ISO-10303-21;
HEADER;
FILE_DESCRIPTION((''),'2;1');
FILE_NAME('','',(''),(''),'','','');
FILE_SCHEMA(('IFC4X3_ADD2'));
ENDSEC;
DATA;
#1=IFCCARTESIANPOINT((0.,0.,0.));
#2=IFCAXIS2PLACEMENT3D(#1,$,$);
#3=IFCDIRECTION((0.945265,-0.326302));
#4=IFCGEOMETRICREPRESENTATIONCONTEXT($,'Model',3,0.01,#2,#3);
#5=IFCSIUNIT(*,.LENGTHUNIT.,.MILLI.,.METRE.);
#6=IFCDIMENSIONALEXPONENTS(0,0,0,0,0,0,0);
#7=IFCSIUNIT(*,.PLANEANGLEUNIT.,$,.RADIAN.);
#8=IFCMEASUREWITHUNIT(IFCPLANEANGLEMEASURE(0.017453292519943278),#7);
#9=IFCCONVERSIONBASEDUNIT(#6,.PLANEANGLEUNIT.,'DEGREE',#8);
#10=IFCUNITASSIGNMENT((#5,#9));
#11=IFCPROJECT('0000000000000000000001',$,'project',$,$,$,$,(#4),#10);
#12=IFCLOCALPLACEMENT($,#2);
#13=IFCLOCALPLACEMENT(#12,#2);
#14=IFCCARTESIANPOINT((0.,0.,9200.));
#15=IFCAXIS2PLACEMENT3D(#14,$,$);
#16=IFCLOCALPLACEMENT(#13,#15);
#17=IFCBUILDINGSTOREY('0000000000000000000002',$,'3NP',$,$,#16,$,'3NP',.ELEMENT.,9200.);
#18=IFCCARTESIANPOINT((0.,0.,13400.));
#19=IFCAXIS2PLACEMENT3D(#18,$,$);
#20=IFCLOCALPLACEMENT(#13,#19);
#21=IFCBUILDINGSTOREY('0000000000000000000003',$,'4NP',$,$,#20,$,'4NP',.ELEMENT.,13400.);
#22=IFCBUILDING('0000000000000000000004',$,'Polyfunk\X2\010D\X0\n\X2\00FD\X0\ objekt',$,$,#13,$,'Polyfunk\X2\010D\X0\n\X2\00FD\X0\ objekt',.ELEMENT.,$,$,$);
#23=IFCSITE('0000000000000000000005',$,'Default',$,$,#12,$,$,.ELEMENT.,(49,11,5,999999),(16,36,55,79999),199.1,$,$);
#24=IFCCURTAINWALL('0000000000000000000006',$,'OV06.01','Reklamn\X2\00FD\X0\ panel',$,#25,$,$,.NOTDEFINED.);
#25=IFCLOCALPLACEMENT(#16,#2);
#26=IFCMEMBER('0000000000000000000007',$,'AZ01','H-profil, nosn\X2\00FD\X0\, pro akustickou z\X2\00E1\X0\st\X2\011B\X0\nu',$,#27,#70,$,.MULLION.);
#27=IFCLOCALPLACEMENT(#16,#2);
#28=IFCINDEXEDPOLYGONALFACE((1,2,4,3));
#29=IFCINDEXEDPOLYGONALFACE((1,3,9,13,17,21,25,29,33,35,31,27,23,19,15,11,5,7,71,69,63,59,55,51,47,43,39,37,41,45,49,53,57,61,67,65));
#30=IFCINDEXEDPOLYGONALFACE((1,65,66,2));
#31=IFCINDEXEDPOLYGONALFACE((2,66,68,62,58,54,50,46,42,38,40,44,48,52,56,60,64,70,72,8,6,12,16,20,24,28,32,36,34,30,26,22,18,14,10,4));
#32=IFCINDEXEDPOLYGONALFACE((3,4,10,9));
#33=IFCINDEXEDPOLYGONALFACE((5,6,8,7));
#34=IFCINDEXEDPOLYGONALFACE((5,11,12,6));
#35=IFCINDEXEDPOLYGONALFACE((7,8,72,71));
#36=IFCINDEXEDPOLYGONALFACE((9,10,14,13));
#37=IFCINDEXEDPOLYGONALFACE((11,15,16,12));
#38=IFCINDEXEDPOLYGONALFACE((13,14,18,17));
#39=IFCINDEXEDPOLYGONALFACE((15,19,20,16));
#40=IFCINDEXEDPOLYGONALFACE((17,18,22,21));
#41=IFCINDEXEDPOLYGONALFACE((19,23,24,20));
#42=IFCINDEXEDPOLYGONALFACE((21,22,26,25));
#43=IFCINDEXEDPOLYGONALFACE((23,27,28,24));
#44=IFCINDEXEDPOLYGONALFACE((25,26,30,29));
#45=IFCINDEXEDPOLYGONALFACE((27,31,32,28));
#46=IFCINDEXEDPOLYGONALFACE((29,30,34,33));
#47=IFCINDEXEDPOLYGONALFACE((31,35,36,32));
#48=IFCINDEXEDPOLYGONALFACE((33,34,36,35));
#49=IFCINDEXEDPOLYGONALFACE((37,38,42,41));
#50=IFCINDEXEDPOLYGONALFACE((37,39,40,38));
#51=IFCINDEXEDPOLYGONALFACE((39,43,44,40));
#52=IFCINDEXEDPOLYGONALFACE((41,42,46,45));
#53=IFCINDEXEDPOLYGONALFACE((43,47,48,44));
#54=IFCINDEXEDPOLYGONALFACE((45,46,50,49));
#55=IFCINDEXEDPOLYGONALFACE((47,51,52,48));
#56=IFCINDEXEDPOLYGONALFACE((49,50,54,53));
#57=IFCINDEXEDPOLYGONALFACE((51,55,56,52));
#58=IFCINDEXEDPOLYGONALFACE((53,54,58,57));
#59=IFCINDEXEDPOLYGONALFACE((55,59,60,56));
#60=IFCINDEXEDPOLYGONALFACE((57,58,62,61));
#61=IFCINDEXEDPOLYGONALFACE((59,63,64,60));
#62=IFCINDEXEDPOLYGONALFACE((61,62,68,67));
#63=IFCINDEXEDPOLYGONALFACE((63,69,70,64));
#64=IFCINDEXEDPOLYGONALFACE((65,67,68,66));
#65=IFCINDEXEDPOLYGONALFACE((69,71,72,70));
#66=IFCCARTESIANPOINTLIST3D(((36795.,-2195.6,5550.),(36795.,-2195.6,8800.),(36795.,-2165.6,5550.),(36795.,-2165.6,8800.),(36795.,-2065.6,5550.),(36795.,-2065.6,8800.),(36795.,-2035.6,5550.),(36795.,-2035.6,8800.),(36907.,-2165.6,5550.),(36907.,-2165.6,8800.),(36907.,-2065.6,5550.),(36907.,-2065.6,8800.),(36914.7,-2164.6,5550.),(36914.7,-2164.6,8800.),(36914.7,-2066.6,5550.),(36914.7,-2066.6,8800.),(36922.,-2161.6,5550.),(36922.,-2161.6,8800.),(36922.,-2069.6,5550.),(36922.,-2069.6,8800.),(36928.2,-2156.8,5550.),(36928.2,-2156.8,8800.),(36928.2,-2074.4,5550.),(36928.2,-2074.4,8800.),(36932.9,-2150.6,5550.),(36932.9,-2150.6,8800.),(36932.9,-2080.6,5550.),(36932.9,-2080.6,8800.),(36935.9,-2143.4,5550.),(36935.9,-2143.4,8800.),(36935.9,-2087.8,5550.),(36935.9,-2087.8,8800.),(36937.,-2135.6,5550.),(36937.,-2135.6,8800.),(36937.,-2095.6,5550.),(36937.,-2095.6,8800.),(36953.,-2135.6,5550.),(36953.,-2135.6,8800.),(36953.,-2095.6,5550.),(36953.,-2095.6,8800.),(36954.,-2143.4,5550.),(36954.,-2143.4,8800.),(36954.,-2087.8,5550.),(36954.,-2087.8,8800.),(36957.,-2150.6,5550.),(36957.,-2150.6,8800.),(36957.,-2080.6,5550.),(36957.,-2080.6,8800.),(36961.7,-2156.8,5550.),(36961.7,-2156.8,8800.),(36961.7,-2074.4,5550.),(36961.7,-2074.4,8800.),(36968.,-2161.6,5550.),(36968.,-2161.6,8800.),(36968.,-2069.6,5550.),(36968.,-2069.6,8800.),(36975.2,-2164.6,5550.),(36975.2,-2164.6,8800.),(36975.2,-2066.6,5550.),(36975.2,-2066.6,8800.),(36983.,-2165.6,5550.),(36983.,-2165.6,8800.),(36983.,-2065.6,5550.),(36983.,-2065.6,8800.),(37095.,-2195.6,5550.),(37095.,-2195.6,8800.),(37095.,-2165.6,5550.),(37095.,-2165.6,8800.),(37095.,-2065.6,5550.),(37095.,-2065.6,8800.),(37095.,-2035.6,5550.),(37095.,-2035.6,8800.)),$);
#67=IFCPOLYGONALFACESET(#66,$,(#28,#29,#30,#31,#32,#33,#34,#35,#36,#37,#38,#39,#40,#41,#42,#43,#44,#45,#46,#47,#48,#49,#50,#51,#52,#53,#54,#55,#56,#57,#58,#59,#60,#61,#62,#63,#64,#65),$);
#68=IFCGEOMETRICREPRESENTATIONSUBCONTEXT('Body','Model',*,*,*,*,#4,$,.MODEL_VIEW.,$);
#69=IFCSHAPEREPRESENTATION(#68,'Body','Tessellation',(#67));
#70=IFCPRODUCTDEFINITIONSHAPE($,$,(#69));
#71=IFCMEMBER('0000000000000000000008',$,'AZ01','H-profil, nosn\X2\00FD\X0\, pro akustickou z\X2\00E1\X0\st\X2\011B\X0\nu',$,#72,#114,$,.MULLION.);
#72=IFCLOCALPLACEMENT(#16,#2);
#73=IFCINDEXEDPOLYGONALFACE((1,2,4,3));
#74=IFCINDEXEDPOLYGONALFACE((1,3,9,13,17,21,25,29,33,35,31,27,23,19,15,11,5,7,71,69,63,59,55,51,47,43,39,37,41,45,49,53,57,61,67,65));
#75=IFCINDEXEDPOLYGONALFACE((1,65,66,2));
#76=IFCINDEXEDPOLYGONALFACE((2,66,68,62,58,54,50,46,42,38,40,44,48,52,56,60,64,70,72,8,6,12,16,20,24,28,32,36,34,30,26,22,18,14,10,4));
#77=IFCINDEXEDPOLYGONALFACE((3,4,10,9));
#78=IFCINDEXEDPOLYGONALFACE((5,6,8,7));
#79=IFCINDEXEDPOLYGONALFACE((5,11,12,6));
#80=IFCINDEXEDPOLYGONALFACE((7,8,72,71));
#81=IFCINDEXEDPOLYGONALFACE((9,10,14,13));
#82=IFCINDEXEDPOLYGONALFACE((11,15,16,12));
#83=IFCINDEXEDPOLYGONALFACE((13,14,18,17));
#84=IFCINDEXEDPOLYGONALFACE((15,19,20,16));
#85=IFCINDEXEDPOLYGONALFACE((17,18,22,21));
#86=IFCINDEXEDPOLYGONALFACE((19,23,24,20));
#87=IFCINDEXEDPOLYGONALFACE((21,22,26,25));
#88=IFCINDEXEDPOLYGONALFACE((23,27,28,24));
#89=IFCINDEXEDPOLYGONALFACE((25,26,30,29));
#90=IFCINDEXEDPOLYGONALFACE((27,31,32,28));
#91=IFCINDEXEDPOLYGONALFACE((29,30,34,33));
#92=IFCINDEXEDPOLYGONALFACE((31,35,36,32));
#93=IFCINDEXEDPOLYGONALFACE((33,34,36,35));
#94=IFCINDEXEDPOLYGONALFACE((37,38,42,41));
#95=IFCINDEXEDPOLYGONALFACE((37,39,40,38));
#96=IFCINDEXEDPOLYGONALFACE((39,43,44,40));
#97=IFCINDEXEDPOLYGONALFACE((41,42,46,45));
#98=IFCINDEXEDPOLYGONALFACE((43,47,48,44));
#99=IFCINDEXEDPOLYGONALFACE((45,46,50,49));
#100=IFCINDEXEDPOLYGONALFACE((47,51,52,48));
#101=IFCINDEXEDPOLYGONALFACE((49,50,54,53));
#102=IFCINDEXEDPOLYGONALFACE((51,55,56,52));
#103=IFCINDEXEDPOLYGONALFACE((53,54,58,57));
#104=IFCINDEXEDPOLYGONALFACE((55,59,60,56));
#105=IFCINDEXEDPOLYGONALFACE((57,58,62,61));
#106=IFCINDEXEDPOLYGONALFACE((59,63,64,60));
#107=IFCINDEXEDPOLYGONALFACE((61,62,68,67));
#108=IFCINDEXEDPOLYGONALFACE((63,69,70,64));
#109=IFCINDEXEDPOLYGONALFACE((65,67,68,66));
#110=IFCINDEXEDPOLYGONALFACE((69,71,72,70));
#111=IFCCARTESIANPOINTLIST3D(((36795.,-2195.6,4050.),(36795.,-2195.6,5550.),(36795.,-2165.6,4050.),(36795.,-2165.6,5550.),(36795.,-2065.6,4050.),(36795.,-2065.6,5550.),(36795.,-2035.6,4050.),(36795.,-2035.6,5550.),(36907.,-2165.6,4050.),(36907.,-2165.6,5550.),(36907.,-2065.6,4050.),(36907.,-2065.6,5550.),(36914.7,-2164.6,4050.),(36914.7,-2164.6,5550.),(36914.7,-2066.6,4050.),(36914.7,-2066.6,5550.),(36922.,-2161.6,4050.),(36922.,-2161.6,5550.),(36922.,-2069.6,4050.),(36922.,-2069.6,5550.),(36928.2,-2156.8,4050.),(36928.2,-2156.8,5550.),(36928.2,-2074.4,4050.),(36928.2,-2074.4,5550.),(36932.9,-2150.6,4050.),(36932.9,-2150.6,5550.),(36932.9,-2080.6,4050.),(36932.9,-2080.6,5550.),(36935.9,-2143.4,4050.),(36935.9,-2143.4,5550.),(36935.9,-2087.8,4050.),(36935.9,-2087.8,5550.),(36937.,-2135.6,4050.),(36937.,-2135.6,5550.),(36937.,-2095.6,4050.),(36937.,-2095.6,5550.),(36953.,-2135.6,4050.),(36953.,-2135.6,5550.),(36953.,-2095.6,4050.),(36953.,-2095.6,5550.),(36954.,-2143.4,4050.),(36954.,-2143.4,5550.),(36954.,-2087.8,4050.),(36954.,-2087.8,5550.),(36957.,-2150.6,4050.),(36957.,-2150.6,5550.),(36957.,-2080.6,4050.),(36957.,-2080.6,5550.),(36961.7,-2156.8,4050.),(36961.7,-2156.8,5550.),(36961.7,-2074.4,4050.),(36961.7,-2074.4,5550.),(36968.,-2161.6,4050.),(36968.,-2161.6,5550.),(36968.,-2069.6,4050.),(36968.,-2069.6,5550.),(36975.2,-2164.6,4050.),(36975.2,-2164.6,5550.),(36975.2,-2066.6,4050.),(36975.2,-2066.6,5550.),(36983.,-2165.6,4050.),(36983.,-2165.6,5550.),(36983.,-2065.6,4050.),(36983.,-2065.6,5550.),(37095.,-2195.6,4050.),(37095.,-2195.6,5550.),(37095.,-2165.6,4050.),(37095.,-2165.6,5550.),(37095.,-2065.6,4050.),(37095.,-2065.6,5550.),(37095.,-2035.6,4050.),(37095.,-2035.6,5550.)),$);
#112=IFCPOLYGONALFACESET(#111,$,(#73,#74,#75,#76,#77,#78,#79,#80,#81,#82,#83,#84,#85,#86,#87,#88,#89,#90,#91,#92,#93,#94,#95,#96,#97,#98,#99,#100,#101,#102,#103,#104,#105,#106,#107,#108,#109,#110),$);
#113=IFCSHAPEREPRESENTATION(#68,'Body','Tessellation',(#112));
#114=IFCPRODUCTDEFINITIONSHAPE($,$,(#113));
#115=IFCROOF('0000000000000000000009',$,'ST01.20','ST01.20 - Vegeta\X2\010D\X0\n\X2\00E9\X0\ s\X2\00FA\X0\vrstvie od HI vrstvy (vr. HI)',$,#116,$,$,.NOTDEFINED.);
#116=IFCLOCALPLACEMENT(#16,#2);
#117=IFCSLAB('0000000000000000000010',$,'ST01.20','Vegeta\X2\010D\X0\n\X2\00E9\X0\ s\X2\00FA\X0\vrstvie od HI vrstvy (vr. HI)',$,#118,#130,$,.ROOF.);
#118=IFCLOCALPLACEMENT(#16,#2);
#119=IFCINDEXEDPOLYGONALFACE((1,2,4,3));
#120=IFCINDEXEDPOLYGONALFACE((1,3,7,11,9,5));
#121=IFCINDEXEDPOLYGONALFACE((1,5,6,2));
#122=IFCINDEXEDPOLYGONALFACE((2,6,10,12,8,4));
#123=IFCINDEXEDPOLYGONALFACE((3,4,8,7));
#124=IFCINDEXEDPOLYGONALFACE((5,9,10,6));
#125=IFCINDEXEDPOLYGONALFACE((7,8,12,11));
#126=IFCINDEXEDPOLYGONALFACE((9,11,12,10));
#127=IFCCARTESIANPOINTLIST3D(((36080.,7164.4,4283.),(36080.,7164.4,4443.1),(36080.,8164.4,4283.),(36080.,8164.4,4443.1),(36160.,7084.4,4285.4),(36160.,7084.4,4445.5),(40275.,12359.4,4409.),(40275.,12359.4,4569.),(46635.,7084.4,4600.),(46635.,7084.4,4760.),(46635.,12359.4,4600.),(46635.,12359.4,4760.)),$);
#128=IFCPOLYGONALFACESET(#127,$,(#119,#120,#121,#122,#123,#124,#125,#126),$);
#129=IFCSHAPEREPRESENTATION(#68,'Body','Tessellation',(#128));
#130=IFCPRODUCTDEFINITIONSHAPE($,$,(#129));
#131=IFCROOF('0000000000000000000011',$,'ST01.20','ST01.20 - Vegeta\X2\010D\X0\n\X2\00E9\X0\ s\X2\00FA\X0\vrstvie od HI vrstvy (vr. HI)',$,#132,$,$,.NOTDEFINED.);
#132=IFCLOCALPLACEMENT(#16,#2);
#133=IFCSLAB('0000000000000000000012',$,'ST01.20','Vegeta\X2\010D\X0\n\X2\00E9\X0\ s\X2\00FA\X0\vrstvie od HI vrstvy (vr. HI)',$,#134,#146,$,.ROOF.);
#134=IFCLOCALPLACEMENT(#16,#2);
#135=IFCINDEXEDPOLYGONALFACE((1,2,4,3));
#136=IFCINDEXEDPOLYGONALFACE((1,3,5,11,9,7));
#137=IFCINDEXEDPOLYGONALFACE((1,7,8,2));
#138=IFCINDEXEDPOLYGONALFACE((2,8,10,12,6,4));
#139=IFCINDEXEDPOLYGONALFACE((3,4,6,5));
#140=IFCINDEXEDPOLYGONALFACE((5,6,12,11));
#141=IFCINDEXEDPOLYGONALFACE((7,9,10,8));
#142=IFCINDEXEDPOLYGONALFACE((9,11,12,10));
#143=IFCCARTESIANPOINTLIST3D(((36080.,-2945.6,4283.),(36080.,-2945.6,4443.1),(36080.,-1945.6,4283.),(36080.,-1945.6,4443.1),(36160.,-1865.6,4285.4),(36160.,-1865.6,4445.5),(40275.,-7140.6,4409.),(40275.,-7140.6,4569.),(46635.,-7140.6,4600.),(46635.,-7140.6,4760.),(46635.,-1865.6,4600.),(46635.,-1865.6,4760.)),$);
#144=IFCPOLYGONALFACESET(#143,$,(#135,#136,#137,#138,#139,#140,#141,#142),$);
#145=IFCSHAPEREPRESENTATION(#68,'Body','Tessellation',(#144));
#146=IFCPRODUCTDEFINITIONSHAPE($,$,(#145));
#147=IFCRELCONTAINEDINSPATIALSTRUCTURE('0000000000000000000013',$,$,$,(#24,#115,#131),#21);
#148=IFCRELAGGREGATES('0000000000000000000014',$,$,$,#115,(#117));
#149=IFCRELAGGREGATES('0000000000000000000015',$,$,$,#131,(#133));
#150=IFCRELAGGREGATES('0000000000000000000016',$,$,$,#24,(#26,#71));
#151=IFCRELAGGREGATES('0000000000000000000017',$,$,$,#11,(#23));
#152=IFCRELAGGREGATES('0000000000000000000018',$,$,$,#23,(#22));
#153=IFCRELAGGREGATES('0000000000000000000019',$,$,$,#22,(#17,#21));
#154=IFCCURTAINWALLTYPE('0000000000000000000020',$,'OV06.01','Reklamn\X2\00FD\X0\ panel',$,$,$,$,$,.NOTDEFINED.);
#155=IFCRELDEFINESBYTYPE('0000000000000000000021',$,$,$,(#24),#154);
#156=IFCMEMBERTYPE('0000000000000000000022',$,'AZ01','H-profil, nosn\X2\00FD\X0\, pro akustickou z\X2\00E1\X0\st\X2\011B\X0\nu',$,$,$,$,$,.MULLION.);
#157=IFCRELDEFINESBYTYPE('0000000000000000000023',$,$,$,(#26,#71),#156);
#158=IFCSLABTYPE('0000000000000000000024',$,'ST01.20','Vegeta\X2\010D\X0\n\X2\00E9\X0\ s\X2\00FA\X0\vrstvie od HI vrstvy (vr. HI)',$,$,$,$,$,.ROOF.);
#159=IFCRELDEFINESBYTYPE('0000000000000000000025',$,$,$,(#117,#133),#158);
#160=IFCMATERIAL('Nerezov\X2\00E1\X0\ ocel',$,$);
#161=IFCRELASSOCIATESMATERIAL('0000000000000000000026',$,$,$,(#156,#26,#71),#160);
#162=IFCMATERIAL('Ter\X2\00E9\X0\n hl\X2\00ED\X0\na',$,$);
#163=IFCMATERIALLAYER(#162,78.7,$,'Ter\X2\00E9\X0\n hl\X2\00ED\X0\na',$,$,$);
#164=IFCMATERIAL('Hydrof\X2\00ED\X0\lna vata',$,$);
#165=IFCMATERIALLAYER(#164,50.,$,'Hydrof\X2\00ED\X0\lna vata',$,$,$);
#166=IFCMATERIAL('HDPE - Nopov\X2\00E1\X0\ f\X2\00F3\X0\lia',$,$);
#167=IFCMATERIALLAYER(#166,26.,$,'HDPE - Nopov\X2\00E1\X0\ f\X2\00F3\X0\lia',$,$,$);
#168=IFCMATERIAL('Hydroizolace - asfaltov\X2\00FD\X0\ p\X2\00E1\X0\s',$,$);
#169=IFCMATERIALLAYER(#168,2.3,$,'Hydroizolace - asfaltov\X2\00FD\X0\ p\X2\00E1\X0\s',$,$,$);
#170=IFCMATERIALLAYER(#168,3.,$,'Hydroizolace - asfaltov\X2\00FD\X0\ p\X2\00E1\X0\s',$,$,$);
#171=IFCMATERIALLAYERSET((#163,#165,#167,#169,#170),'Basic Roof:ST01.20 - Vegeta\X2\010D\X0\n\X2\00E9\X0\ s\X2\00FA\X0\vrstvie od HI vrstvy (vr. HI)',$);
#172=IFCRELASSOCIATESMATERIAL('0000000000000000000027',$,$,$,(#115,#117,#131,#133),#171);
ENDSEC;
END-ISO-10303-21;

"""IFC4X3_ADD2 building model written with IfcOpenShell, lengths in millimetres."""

from ifc_helpers import new_model, entity, si_unit, converted_unit, direction, frame, frame_2d, origin, place, context, subcontext, project, spatial, polyline, circle_curve, parameter, trimmed, segment, composite_curve, outline, extrude, source, transform, mapped, material, layer, layer_set, material_profile, profile_set, profile_usage, type_object, type_shapes, element, aggregate, save


model = new_model("IFC4X3_ADD2")

# Units and contexts
model_context = context("Model", 3, precision=0.01, world=origin(), true_north=direction((0.945265, -0.326302)))
body_context = subcontext(model_context, "Body", "Model", "MODEL_VIEW")
ifc_project = project(units=[si_unit("LENGTHUNIT", "METRE", prefix="MILLI"), converted_unit("PLANEANGLEUNIT", "DEGREE", entity("IfcPlaneAngleMeasure", 0.017453292519943278), si_unit("PLANEANGLEUNIT", "RADIAN"), dimensions=[0, 0, 0, 0, 0, 0, 0])], contexts=[model_context])

# Site, building, storey
site_placement = place(None, origin())
site = spatial("IfcSite", under=ifc_project, at=site_placement, Name="Default", CompositionType="ELEMENT", RefLatitude=(49, 11, 5, 999999), RefLongitude=(16, 36, 55, 79999), RefElevation=199.1)
building_placement = place(site_placement, origin())
building = spatial("IfcBuilding", under=site, at=building_placement, Name="Polyfunkčný objekt", LongName="Polyfunkčný objekt", CompositionType="ELEMENT")
storey_1_placement = place(building_placement, frame((0.0, 0.0, 9200.0)))
storey_1 = spatial("IfcBuildingStorey", under=building, at=storey_1_placement, Name="3NP", LongName="3NP", CompositionType="ELEMENT", Elevation=9200.0)

# Shared definitions
storey_2_placement = place(building_placement, frame((0.0, 0.0, 13400.0)))
storey_2 = spatial("IfcBuildingStorey", under=building, at=storey_2_placement, Name="4NP", LongName="4NP", CompositionType="ELEMENT", Elevation=13400.0)

# Curtain wall, members
curtain_wall_type_1 = type_object("IfcCurtainWallType", Name="OV06.01", Description="Reklamný panel", PredefinedType="NOTDEFINED")
curtain_wall_1_placement = place(storey_2_placement, frame((0.0, 0.0, -13400.0)))
curtain_wall_1 = element("IfcCurtainWall", 1, at=curtain_wall_1_placement, inside=storey_2, type_object=curtain_wall_type_1, Name="OV06.01", Description="Reklamný panel", PredefinedType="NOTDEFINED")
ifc_material_1 = material(Name="Nerezová ocel")
ifc_material_profile_1 = material_profile(ifc_material_1, outline(composite_curve([segment(polyline([(50.0, -150.0), (80.0, -150.0)]), True, "CONTINUOUS"), segment(polyline([(80.0, -150.0), (80.0, 150.0)]), True, "CONTINUOUS"), segment(polyline([(80.0, 150.0), (50.0, 150.0)]), True, "CONTINUOUS"), segment(polyline([(50.0, 150.0), (50.0, 38.0)]), True, "CONTINUOUS"), segment(trimmed(circle_curve(frame_2d((20.0, 38.0), x_axis=(0.0, 1.0)), 30.0), [parameter(180.0)], [parameter(270.0)], True, "PARAMETER"), False, "CONTINUOUS"), segment(polyline([(20.0, 8.0), (-20.0, 8.0)]), True, "CONTINUOUS"), segment(trimmed(circle_curve(frame_2d((-20.0, 38.0), x_axis=(0.0, 1.0)), 30.0), [parameter(90.0)], [parameter(180.0)], True, "PARAMETER"), False, "CONTINUOUS"), segment(polyline([(-50.0, 38.0), (-50.0, 150.0)]), True, "CONTINUOUS"), segment(polyline([(-50.0, 150.0), (-80.0, 150.0)]), True, "CONTINUOUS"), segment(polyline([(-80.0, 150.0), (-80.0, -150.0)]), True, "CONTINUOUS"), segment(polyline([(-80.0, -150.0), (-50.0, -150.0)]), True, "CONTINUOUS"), segment(polyline([(-50.0, -150.0), (-50.0, -38.0)]), True, "CONTINUOUS"), segment(trimmed(circle_curve(frame_2d((-20.0, -38.0), x_axis=(0.0, 1.0)), 30.0), [parameter(0.0)], [parameter(90.0)], True, "PARAMETER"), False, "CONTINUOUS"), segment(polyline([(-20.0, -8.0), (20.0, -8.0)]), True, "CONTINUOUS"), segment(trimmed(circle_curve(frame_2d((20.0, -38.0), x_axis=(0.0, 1.0)), 30.0), [parameter(270.0)], [parameter(0.0)], True, "PARAMETER"), False, "CONTINUOUS"), segment(polyline([(50.0, -38.0), (50.0, -150.0)]), True, "CONTINUOUS")], self_intersect=False)), Name="Profil zástena")
ifc_profile_set_1 = profile_set([ifc_material_profile_1], Name="Profil zástena")
ifc_profile_usage_1 = profile_usage(ifc_profile_set_1)
member_type_1 = type_object("IfcMemberType", Name="AZ01", Description="H-profil, nosný, pro akustickou zástěnu", PredefinedType="MULLION", material=ifc_profile_set_1)
shared_shape_1 = source(origin(), body_context, "Body", "SweptSolid", [
    extrude(outline(composite_curve([segment(polyline([(50.0, -150.0), (80.0, -150.0)]), True, "CONTINUOUS"), segment(polyline([(80.0, -150.0), (80.0, 150.0)]), True, "CONTINUOUS"), segment(polyline([(80.0, 150.0), (50.0, 150.0)]), True, "CONTINUOUS"), segment(polyline([(50.0, 150.0), (50.0, 38.0)]), True, "CONTINUOUS"), segment(trimmed(circle_curve(frame_2d((20.0, 38.0), x_axis=(0.0, 1.0)), 30.0), [parameter(180.0)], [parameter(270.0)], True, "PARAMETER"), False, "CONTINUOUS"), segment(polyline([(20.0, 8.0), (-20.0, 8.0)]), True, "CONTINUOUS"), segment(trimmed(circle_curve(frame_2d((-20.0, 38.0), x_axis=(0.0, 1.0)), 30.0), [parameter(90.0)], [parameter(180.0)], True, "PARAMETER"), False, "CONTINUOUS"), segment(polyline([(-50.0, 38.0), (-50.0, 150.0)]), True, "CONTINUOUS"), segment(polyline([(-50.0, 150.0), (-80.0, 150.0)]), True, "CONTINUOUS"), segment(polyline([(-80.0, 150.0), (-80.0, -150.0)]), True, "CONTINUOUS"), segment(polyline([(-80.0, -150.0), (-50.0, -150.0)]), True, "CONTINUOUS"), segment(polyline([(-50.0, -150.0), (-50.0, -38.0)]), True, "CONTINUOUS"), segment(trimmed(circle_curve(frame_2d((-20.0, -38.0), x_axis=(0.0, 1.0)), 30.0), [parameter(0.0)], [parameter(90.0)], True, "PARAMETER"), False, "CONTINUOUS"), segment(polyline([(-20.0, -8.0), (20.0, -8.0)]), True, "CONTINUOUS"), segment(trimmed(circle_curve(frame_2d((20.0, -38.0), x_axis=(0.0, 1.0)), 30.0), [parameter(270.0)], [parameter(0.0)], True, "PARAMETER"), False, "CONTINUOUS"), segment(polyline([(50.0, -38.0), (50.0, -150.0)]), True, "CONTINUOUS")], self_intersect=False)), frame((-150.0, 0.0, -3250.0), z_axis=(0.0, 0.0, 1.0), x_axis=(0.0, 1.0, 0.0)), (0.0, 0.0, 1.0), 3250.0),
])
member_1_placement = place(curtain_wall_1_placement, frame((36795.0, -2115.6, 18000.0), z_axis=(0.0, 0.0, 1.0), x_axis=(-1.0, 0.0, 0.0)))
member_1 = element("IfcMember", 2, at=member_1_placement, type_object=member_type_1, material=ifc_profile_usage_1, Name="AZ01", Description="H-profil, nosný, pro akustickou zástěnu", PredefinedType="MULLION", context=body_context, shape_type="MappedRepresentation", body=[
    mapped(shared_shape_1, transform((0.0, 0.0, 0.0), scale=1.0)),
])
shared_shape_2 = source(origin(), body_context, "Body", "SweptSolid", [
    extrude(outline(composite_curve([segment(polyline([(50.0, -150.0), (80.0, -150.0)]), True, "CONTINUOUS"), segment(polyline([(80.0, -150.0), (80.0, 150.0)]), True, "CONTINUOUS"), segment(polyline([(80.0, 150.0), (50.0, 150.0)]), True, "CONTINUOUS"), segment(polyline([(50.0, 150.0), (50.0, 38.0)]), True, "CONTINUOUS"), segment(trimmed(circle_curve(frame_2d((20.0, 38.0), x_axis=(0.0, 1.0)), 30.0), [parameter(180.0)], [parameter(270.0)], True, "PARAMETER"), False, "CONTINUOUS"), segment(polyline([(20.0, 8.0), (-20.0, 8.0)]), True, "CONTINUOUS"), segment(trimmed(circle_curve(frame_2d((-20.0, 38.0), x_axis=(0.0, 1.0)), 30.0), [parameter(90.0)], [parameter(180.0)], True, "PARAMETER"), False, "CONTINUOUS"), segment(polyline([(-50.0, 38.0), (-50.0, 150.0)]), True, "CONTINUOUS"), segment(polyline([(-50.0, 150.0), (-80.0, 150.0)]), True, "CONTINUOUS"), segment(polyline([(-80.0, 150.0), (-80.0, -150.0)]), True, "CONTINUOUS"), segment(polyline([(-80.0, -150.0), (-50.0, -150.0)]), True, "CONTINUOUS"), segment(polyline([(-50.0, -150.0), (-50.0, -38.0)]), True, "CONTINUOUS"), segment(trimmed(circle_curve(frame_2d((-20.0, -38.0), x_axis=(0.0, 1.0)), 30.0), [parameter(0.0)], [parameter(90.0)], True, "PARAMETER"), False, "CONTINUOUS"), segment(polyline([(-20.0, -8.0), (20.0, -8.0)]), True, "CONTINUOUS"), segment(trimmed(circle_curve(frame_2d((20.0, -38.0), x_axis=(0.0, 1.0)), 30.0), [parameter(270.0)], [parameter(0.0)], True, "PARAMETER"), False, "CONTINUOUS"), segment(polyline([(50.0, -38.0), (50.0, -150.0)]), True, "CONTINUOUS")], self_intersect=False)), frame((-150.0, 0.0, -1500.0), z_axis=(0.0, 0.0, 1.0), x_axis=(0.0, 1.0, 0.0)), (0.0, 0.0, 1.0), 1500.0),
])
type_shapes(member_type_1, [shared_shape_1, shared_shape_2])
member_2_placement = place(curtain_wall_1_placement, frame((36795.0, -2115.6, 14750.0), z_axis=(0.0, 0.0, 1.0), x_axis=(-1.0, 0.0, 0.0)))
member_2 = element("IfcMember", 3, at=member_2_placement, type_object=member_type_1, material=ifc_profile_usage_1, Name="AZ01", Description="H-profil, nosný, pro akustickou zástěnu", PredefinedType="MULLION", context=body_context, shape_type="MappedRepresentation", body=[
    mapped(shared_shape_2, transform((0.0, 0.0, 0.0), scale=1.0)),
])

# Roofs, slabs
ifc_material_2 = material(Name="Terén hlína")
ifc_layer_1 = layer(ifc_material_2, 78.7, Name="Terén hlína")
ifc_material_3 = material(Name="Hydrofílna vata")
ifc_layer_2 = layer(ifc_material_3, 50.0, Name="Hydrofílna vata")
ifc_material_4 = material(Name="HDPE - Nopová fólia")
ifc_layer_3 = layer(ifc_material_4, 26.0, Name="HDPE - Nopová fólia")
ifc_material_5 = material(Name="Hydroizolace - asfaltový pás")
ifc_layer_4 = layer(ifc_material_5, 2.3, Name="Hydroizolace - asfaltový pás")
ifc_layer_5 = layer(ifc_material_5, 3.0, Name="Hydroizolace - asfaltový pás")
ifc_layer_set_1 = layer_set([ifc_layer_1, ifc_layer_2, ifc_layer_3, ifc_layer_4, ifc_layer_5], Name="Basic Roof:ST01.20 - Vegetačné súvrstvie od HI vrstvy (vr. HI)")
roof_1_placement = place(storey_2_placement, frame((36080.0, 7084.4, 83.0)))
roof_1 = element("IfcRoof", 4, at=roof_1_placement, inside=storey_2, material=ifc_layer_set_1, Name="ST01.20", Description="ST01.20 - Vegetačné súvrstvie od HI vrstvy (vr. HI)", PredefinedType="NOTDEFINED")
slab_type_1 = type_object("IfcSlabType", Name="ST01.20", Description="Vegetačné súvrstvie od HI vrstvy (vr. HI)", PredefinedType="ROOF")
slab_1_placement = place(roof_1_placement, origin())
slab_1 = element("IfcSlab", 5, at=slab_1_placement, type_object=slab_type_1, material=ifc_layer_set_1, Name="ST01.20", Description="Vegetačné súvrstvie od HI vrstvy (vr. HI)", PredefinedType="ROOF", context=body_context, shape_type="SweptSolid", body=[
    extrude(outline(polyline([(-5279.9, -2557.5), (-5199.8, -2637.5), (5279.9, -2637.5), (5279.9, 2637.5), (-1083.0, 2637.5), (-5279.9, -1557.5), (-5279.9, -2557.5)])), frame((5277.5, 2637.5, 158.5), z_axis=(-0.030015, 0.0, 0.999549), x_axis=(0.999549, 0.0, 0.030015)), (0.030015, 0.0, 0.999549), 160.1),
])
aggregate(roof_1, [slab_1])
roof_2_placement = place(storey_2_placement, frame((36080.0, -7140.6, 83.0)))
roof_2 = element("IfcRoof", 6, at=roof_2_placement, inside=storey_2, material=ifc_layer_set_1, Name="ST01.20", Description="ST01.20 - Vegetačné súvrstvie od HI vrstvy (vr. HI)", PredefinedType="NOTDEFINED")
slab_2_placement = place(roof_2_placement, origin())
slab_2 = element("IfcSlab", 7, at=slab_2_placement, type_object=slab_type_1, material=ifc_layer_set_1, Name="ST01.20", Description="Vegetačné súvrstvie od HI vrstvy (vr. HI)", PredefinedType="ROOF", context=body_context, shape_type="SweptSolid", body=[
    extrude(outline(polyline([(-5279.9, 1557.5), (-1083.0, -2637.5), (5279.9, -2637.5), (5279.9, 2637.5), (-5199.8, 2637.5), (-5279.9, 2557.5), (-5279.9, 1557.5)])), frame((5277.5, 2637.5, 158.5), z_axis=(-0.030015, 0.0, 0.999549), x_axis=(0.999549, 0.0, 0.030015)), (0.030015, 0.0, 0.999549), 160.1),
])
aggregate(roof_2, [slab_2])

aggregate(curtain_wall_1, [member_1, member_2])

save(model, "model.ifc")
